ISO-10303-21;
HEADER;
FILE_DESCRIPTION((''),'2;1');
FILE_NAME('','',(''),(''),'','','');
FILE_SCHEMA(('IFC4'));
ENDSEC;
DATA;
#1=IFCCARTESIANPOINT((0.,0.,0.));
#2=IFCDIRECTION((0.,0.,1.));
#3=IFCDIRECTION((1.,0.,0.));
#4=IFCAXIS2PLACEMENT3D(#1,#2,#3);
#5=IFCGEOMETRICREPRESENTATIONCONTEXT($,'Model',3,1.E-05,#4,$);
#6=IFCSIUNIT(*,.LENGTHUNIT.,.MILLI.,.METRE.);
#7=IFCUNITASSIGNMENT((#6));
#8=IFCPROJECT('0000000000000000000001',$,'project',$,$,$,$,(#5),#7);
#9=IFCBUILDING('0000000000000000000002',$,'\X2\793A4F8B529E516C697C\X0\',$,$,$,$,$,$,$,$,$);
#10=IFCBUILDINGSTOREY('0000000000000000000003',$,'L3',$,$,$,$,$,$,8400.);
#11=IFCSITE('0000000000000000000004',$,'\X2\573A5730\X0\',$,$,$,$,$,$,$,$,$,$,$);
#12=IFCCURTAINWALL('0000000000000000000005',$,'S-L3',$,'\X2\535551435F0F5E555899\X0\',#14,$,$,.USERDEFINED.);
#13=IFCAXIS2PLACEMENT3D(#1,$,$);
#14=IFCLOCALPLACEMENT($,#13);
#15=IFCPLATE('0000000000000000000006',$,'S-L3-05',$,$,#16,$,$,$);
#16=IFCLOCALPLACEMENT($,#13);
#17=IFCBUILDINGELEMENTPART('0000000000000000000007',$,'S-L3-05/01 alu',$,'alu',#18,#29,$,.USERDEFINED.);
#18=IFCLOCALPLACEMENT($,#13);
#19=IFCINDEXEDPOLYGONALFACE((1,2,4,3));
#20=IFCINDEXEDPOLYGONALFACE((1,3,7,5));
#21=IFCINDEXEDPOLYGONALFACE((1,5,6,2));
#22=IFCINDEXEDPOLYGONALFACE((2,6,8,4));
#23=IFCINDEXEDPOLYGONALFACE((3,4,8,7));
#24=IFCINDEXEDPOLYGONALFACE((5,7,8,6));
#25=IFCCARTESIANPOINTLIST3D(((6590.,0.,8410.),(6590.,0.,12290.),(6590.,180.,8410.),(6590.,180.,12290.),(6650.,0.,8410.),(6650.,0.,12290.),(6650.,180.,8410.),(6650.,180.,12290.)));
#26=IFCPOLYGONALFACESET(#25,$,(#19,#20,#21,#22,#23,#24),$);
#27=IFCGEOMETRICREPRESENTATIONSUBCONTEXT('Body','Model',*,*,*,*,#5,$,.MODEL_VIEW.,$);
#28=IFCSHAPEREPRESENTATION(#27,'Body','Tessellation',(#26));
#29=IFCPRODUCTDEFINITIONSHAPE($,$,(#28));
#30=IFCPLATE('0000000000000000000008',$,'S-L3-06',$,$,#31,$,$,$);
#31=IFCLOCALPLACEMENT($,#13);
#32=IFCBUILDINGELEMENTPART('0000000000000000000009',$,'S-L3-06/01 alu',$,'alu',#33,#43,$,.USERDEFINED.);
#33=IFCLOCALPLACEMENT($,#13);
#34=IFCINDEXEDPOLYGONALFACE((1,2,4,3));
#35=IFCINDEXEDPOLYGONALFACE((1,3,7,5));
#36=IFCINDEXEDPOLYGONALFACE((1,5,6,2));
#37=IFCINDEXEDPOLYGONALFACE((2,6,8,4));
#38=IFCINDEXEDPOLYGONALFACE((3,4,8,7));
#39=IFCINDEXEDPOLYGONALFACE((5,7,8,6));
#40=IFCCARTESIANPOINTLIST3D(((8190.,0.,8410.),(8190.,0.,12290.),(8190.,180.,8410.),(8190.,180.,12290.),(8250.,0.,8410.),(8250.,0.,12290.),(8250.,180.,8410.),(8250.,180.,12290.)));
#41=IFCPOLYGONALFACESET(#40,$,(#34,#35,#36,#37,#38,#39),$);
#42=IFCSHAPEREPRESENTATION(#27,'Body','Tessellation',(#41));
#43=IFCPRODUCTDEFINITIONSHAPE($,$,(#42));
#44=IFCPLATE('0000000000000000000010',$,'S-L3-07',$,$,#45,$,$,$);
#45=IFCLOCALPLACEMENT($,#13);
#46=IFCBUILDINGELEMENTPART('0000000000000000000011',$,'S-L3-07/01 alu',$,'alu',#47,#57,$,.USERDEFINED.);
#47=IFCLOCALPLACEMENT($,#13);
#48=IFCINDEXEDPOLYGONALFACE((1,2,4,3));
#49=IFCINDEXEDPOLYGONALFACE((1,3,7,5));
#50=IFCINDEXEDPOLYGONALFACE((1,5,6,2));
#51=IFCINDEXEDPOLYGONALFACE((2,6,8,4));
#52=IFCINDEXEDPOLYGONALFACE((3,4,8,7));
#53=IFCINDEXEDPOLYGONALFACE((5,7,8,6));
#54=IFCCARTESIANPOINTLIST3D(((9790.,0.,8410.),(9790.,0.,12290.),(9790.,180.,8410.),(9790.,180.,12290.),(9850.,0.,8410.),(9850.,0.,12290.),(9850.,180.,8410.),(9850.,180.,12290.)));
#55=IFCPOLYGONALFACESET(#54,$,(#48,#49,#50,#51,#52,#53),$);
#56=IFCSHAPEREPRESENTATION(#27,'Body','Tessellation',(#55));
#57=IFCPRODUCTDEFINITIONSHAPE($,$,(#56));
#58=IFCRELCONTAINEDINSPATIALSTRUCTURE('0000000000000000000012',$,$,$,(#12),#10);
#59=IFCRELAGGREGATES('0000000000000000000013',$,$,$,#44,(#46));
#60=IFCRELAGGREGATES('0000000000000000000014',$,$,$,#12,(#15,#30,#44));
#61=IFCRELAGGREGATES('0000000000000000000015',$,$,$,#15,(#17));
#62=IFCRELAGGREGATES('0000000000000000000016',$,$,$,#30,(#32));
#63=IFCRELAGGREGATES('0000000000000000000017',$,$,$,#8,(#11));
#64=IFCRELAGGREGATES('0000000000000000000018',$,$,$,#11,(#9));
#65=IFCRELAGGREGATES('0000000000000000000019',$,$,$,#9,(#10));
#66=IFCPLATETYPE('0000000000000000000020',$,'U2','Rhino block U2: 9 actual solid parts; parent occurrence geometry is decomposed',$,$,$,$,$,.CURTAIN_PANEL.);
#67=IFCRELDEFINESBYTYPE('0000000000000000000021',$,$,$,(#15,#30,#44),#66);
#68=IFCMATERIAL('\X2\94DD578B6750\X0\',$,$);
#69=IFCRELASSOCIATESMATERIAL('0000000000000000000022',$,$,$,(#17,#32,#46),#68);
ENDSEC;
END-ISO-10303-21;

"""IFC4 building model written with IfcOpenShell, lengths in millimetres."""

from ifc_helpers import new_model, si_unit, frame, frame_2d, origin, origin_with_axes, place, context, subcontext, project, spatial, rectangle, extrude, source, transform, mapped, material, type_object, element, aggregate, save


model = new_model("IFC4")

# Units and contexts
model_context = context("Model", 3, precision=1e-05, world=origin_with_axes())
body_context = subcontext(model_context, "Body", "Model", "MODEL_VIEW")
ifc_project = project(units=[si_unit("LENGTHUNIT", "METRE", prefix="MILLI")], contexts=[model_context])

# Site, building, storey
site = spatial("IfcSite", under=ifc_project, Name="场地")
building = spatial("IfcBuilding", under=site, Name="示例办公楼")
storey = spatial("IfcBuildingStorey", under=building, Name="L3", Elevation=8400.0)

# Curtain wall, plates, building element parts
curtain_wall = element("IfcCurtainWall", 1, inside=storey, Name="S-L3", ObjectType="单元式幕墙", PredefinedType="USERDEFINED")
plate_type = type_object("IfcPlateType", Name="U2", Description="Rhino block U2: 9 actual solid parts; parent occurrence geometry is decomposed", PredefinedType="CURTAIN_PANEL")
plate_1_placement = place(None, frame((6590.0, 0.0, 8410.0), z_axis=(0.0, 0.0, 1.0), x_axis=(1.0, 0.0, 0.0)))
plate_1 = element("IfcPlate", 2, at=plate_1_placement, type_object=plate_type, Name="S-L3-05")
ifc_material_1 = material(Name="铝型材")
shared_shape_1 = source(origin(), body_context, "Body", "SweptSolid", [
    extrude(rectangle(XDim=60.0, YDim=180.0, at=frame_2d((30.0, 90.0))), origin(), (0.0, 0.0, 1.0), 3880.0),
])
building_element_part_1_placement = place(plate_1_placement, origin())
building_element_part_1 = element("IfcBuildingElementPart", 3, at=building_element_part_1_placement, material=ifc_material_1, Name="S-L3-05/01 alu", ObjectType="alu", PredefinedType="USERDEFINED", context=body_context, shape_type="MappedRepresentation", body=[
    mapped(shared_shape_1, transform((0.0, 0.0, 0.0))),
])
plate_2_placement = place(None, frame((8190.0, 0.0, 8410.0), z_axis=(0.0, 0.0, 1.0), x_axis=(1.0, 0.0, 0.0)))
plate_2 = element("IfcPlate", 4, at=plate_2_placement, type_object=plate_type, Name="S-L3-06")
building_element_part_2_placement = place(plate_2_placement, origin())
building_element_part_2 = element("IfcBuildingElementPart", 5, at=building_element_part_2_placement, material=ifc_material_1, Name="S-L3-06/01 alu", ObjectType="alu", PredefinedType="USERDEFINED", context=body_context, shape_type="MappedRepresentation", body=[
    mapped(shared_shape_1, transform((0.0, 0.0, 0.0))),
])
plate_3_placement = place(None, frame((9790.0, 0.0, 8410.0), z_axis=(0.0, 0.0, 1.0), x_axis=(1.0, 0.0, 0.0)))
plate_3 = element("IfcPlate", 6, at=plate_3_placement, type_object=plate_type, Name="S-L3-07")
building_element_part_3_placement = place(plate_3_placement, origin())
building_element_part_3 = element("IfcBuildingElementPart", 7, at=building_element_part_3_placement, material=ifc_material_1, Name="S-L3-07/01 alu", ObjectType="alu", PredefinedType="USERDEFINED", context=body_context, shape_type="MappedRepresentation", body=[
    mapped(shared_shape_1, transform((0.0, 0.0, 0.0))),
])
aggregate(plate_3, [building_element_part_3])
aggregate(curtain_wall, [plate_1, plate_2, plate_3])
aggregate(plate_1, [building_element_part_1])
aggregate(plate_2, [building_element_part_2])

save(model, "model.ifc")
